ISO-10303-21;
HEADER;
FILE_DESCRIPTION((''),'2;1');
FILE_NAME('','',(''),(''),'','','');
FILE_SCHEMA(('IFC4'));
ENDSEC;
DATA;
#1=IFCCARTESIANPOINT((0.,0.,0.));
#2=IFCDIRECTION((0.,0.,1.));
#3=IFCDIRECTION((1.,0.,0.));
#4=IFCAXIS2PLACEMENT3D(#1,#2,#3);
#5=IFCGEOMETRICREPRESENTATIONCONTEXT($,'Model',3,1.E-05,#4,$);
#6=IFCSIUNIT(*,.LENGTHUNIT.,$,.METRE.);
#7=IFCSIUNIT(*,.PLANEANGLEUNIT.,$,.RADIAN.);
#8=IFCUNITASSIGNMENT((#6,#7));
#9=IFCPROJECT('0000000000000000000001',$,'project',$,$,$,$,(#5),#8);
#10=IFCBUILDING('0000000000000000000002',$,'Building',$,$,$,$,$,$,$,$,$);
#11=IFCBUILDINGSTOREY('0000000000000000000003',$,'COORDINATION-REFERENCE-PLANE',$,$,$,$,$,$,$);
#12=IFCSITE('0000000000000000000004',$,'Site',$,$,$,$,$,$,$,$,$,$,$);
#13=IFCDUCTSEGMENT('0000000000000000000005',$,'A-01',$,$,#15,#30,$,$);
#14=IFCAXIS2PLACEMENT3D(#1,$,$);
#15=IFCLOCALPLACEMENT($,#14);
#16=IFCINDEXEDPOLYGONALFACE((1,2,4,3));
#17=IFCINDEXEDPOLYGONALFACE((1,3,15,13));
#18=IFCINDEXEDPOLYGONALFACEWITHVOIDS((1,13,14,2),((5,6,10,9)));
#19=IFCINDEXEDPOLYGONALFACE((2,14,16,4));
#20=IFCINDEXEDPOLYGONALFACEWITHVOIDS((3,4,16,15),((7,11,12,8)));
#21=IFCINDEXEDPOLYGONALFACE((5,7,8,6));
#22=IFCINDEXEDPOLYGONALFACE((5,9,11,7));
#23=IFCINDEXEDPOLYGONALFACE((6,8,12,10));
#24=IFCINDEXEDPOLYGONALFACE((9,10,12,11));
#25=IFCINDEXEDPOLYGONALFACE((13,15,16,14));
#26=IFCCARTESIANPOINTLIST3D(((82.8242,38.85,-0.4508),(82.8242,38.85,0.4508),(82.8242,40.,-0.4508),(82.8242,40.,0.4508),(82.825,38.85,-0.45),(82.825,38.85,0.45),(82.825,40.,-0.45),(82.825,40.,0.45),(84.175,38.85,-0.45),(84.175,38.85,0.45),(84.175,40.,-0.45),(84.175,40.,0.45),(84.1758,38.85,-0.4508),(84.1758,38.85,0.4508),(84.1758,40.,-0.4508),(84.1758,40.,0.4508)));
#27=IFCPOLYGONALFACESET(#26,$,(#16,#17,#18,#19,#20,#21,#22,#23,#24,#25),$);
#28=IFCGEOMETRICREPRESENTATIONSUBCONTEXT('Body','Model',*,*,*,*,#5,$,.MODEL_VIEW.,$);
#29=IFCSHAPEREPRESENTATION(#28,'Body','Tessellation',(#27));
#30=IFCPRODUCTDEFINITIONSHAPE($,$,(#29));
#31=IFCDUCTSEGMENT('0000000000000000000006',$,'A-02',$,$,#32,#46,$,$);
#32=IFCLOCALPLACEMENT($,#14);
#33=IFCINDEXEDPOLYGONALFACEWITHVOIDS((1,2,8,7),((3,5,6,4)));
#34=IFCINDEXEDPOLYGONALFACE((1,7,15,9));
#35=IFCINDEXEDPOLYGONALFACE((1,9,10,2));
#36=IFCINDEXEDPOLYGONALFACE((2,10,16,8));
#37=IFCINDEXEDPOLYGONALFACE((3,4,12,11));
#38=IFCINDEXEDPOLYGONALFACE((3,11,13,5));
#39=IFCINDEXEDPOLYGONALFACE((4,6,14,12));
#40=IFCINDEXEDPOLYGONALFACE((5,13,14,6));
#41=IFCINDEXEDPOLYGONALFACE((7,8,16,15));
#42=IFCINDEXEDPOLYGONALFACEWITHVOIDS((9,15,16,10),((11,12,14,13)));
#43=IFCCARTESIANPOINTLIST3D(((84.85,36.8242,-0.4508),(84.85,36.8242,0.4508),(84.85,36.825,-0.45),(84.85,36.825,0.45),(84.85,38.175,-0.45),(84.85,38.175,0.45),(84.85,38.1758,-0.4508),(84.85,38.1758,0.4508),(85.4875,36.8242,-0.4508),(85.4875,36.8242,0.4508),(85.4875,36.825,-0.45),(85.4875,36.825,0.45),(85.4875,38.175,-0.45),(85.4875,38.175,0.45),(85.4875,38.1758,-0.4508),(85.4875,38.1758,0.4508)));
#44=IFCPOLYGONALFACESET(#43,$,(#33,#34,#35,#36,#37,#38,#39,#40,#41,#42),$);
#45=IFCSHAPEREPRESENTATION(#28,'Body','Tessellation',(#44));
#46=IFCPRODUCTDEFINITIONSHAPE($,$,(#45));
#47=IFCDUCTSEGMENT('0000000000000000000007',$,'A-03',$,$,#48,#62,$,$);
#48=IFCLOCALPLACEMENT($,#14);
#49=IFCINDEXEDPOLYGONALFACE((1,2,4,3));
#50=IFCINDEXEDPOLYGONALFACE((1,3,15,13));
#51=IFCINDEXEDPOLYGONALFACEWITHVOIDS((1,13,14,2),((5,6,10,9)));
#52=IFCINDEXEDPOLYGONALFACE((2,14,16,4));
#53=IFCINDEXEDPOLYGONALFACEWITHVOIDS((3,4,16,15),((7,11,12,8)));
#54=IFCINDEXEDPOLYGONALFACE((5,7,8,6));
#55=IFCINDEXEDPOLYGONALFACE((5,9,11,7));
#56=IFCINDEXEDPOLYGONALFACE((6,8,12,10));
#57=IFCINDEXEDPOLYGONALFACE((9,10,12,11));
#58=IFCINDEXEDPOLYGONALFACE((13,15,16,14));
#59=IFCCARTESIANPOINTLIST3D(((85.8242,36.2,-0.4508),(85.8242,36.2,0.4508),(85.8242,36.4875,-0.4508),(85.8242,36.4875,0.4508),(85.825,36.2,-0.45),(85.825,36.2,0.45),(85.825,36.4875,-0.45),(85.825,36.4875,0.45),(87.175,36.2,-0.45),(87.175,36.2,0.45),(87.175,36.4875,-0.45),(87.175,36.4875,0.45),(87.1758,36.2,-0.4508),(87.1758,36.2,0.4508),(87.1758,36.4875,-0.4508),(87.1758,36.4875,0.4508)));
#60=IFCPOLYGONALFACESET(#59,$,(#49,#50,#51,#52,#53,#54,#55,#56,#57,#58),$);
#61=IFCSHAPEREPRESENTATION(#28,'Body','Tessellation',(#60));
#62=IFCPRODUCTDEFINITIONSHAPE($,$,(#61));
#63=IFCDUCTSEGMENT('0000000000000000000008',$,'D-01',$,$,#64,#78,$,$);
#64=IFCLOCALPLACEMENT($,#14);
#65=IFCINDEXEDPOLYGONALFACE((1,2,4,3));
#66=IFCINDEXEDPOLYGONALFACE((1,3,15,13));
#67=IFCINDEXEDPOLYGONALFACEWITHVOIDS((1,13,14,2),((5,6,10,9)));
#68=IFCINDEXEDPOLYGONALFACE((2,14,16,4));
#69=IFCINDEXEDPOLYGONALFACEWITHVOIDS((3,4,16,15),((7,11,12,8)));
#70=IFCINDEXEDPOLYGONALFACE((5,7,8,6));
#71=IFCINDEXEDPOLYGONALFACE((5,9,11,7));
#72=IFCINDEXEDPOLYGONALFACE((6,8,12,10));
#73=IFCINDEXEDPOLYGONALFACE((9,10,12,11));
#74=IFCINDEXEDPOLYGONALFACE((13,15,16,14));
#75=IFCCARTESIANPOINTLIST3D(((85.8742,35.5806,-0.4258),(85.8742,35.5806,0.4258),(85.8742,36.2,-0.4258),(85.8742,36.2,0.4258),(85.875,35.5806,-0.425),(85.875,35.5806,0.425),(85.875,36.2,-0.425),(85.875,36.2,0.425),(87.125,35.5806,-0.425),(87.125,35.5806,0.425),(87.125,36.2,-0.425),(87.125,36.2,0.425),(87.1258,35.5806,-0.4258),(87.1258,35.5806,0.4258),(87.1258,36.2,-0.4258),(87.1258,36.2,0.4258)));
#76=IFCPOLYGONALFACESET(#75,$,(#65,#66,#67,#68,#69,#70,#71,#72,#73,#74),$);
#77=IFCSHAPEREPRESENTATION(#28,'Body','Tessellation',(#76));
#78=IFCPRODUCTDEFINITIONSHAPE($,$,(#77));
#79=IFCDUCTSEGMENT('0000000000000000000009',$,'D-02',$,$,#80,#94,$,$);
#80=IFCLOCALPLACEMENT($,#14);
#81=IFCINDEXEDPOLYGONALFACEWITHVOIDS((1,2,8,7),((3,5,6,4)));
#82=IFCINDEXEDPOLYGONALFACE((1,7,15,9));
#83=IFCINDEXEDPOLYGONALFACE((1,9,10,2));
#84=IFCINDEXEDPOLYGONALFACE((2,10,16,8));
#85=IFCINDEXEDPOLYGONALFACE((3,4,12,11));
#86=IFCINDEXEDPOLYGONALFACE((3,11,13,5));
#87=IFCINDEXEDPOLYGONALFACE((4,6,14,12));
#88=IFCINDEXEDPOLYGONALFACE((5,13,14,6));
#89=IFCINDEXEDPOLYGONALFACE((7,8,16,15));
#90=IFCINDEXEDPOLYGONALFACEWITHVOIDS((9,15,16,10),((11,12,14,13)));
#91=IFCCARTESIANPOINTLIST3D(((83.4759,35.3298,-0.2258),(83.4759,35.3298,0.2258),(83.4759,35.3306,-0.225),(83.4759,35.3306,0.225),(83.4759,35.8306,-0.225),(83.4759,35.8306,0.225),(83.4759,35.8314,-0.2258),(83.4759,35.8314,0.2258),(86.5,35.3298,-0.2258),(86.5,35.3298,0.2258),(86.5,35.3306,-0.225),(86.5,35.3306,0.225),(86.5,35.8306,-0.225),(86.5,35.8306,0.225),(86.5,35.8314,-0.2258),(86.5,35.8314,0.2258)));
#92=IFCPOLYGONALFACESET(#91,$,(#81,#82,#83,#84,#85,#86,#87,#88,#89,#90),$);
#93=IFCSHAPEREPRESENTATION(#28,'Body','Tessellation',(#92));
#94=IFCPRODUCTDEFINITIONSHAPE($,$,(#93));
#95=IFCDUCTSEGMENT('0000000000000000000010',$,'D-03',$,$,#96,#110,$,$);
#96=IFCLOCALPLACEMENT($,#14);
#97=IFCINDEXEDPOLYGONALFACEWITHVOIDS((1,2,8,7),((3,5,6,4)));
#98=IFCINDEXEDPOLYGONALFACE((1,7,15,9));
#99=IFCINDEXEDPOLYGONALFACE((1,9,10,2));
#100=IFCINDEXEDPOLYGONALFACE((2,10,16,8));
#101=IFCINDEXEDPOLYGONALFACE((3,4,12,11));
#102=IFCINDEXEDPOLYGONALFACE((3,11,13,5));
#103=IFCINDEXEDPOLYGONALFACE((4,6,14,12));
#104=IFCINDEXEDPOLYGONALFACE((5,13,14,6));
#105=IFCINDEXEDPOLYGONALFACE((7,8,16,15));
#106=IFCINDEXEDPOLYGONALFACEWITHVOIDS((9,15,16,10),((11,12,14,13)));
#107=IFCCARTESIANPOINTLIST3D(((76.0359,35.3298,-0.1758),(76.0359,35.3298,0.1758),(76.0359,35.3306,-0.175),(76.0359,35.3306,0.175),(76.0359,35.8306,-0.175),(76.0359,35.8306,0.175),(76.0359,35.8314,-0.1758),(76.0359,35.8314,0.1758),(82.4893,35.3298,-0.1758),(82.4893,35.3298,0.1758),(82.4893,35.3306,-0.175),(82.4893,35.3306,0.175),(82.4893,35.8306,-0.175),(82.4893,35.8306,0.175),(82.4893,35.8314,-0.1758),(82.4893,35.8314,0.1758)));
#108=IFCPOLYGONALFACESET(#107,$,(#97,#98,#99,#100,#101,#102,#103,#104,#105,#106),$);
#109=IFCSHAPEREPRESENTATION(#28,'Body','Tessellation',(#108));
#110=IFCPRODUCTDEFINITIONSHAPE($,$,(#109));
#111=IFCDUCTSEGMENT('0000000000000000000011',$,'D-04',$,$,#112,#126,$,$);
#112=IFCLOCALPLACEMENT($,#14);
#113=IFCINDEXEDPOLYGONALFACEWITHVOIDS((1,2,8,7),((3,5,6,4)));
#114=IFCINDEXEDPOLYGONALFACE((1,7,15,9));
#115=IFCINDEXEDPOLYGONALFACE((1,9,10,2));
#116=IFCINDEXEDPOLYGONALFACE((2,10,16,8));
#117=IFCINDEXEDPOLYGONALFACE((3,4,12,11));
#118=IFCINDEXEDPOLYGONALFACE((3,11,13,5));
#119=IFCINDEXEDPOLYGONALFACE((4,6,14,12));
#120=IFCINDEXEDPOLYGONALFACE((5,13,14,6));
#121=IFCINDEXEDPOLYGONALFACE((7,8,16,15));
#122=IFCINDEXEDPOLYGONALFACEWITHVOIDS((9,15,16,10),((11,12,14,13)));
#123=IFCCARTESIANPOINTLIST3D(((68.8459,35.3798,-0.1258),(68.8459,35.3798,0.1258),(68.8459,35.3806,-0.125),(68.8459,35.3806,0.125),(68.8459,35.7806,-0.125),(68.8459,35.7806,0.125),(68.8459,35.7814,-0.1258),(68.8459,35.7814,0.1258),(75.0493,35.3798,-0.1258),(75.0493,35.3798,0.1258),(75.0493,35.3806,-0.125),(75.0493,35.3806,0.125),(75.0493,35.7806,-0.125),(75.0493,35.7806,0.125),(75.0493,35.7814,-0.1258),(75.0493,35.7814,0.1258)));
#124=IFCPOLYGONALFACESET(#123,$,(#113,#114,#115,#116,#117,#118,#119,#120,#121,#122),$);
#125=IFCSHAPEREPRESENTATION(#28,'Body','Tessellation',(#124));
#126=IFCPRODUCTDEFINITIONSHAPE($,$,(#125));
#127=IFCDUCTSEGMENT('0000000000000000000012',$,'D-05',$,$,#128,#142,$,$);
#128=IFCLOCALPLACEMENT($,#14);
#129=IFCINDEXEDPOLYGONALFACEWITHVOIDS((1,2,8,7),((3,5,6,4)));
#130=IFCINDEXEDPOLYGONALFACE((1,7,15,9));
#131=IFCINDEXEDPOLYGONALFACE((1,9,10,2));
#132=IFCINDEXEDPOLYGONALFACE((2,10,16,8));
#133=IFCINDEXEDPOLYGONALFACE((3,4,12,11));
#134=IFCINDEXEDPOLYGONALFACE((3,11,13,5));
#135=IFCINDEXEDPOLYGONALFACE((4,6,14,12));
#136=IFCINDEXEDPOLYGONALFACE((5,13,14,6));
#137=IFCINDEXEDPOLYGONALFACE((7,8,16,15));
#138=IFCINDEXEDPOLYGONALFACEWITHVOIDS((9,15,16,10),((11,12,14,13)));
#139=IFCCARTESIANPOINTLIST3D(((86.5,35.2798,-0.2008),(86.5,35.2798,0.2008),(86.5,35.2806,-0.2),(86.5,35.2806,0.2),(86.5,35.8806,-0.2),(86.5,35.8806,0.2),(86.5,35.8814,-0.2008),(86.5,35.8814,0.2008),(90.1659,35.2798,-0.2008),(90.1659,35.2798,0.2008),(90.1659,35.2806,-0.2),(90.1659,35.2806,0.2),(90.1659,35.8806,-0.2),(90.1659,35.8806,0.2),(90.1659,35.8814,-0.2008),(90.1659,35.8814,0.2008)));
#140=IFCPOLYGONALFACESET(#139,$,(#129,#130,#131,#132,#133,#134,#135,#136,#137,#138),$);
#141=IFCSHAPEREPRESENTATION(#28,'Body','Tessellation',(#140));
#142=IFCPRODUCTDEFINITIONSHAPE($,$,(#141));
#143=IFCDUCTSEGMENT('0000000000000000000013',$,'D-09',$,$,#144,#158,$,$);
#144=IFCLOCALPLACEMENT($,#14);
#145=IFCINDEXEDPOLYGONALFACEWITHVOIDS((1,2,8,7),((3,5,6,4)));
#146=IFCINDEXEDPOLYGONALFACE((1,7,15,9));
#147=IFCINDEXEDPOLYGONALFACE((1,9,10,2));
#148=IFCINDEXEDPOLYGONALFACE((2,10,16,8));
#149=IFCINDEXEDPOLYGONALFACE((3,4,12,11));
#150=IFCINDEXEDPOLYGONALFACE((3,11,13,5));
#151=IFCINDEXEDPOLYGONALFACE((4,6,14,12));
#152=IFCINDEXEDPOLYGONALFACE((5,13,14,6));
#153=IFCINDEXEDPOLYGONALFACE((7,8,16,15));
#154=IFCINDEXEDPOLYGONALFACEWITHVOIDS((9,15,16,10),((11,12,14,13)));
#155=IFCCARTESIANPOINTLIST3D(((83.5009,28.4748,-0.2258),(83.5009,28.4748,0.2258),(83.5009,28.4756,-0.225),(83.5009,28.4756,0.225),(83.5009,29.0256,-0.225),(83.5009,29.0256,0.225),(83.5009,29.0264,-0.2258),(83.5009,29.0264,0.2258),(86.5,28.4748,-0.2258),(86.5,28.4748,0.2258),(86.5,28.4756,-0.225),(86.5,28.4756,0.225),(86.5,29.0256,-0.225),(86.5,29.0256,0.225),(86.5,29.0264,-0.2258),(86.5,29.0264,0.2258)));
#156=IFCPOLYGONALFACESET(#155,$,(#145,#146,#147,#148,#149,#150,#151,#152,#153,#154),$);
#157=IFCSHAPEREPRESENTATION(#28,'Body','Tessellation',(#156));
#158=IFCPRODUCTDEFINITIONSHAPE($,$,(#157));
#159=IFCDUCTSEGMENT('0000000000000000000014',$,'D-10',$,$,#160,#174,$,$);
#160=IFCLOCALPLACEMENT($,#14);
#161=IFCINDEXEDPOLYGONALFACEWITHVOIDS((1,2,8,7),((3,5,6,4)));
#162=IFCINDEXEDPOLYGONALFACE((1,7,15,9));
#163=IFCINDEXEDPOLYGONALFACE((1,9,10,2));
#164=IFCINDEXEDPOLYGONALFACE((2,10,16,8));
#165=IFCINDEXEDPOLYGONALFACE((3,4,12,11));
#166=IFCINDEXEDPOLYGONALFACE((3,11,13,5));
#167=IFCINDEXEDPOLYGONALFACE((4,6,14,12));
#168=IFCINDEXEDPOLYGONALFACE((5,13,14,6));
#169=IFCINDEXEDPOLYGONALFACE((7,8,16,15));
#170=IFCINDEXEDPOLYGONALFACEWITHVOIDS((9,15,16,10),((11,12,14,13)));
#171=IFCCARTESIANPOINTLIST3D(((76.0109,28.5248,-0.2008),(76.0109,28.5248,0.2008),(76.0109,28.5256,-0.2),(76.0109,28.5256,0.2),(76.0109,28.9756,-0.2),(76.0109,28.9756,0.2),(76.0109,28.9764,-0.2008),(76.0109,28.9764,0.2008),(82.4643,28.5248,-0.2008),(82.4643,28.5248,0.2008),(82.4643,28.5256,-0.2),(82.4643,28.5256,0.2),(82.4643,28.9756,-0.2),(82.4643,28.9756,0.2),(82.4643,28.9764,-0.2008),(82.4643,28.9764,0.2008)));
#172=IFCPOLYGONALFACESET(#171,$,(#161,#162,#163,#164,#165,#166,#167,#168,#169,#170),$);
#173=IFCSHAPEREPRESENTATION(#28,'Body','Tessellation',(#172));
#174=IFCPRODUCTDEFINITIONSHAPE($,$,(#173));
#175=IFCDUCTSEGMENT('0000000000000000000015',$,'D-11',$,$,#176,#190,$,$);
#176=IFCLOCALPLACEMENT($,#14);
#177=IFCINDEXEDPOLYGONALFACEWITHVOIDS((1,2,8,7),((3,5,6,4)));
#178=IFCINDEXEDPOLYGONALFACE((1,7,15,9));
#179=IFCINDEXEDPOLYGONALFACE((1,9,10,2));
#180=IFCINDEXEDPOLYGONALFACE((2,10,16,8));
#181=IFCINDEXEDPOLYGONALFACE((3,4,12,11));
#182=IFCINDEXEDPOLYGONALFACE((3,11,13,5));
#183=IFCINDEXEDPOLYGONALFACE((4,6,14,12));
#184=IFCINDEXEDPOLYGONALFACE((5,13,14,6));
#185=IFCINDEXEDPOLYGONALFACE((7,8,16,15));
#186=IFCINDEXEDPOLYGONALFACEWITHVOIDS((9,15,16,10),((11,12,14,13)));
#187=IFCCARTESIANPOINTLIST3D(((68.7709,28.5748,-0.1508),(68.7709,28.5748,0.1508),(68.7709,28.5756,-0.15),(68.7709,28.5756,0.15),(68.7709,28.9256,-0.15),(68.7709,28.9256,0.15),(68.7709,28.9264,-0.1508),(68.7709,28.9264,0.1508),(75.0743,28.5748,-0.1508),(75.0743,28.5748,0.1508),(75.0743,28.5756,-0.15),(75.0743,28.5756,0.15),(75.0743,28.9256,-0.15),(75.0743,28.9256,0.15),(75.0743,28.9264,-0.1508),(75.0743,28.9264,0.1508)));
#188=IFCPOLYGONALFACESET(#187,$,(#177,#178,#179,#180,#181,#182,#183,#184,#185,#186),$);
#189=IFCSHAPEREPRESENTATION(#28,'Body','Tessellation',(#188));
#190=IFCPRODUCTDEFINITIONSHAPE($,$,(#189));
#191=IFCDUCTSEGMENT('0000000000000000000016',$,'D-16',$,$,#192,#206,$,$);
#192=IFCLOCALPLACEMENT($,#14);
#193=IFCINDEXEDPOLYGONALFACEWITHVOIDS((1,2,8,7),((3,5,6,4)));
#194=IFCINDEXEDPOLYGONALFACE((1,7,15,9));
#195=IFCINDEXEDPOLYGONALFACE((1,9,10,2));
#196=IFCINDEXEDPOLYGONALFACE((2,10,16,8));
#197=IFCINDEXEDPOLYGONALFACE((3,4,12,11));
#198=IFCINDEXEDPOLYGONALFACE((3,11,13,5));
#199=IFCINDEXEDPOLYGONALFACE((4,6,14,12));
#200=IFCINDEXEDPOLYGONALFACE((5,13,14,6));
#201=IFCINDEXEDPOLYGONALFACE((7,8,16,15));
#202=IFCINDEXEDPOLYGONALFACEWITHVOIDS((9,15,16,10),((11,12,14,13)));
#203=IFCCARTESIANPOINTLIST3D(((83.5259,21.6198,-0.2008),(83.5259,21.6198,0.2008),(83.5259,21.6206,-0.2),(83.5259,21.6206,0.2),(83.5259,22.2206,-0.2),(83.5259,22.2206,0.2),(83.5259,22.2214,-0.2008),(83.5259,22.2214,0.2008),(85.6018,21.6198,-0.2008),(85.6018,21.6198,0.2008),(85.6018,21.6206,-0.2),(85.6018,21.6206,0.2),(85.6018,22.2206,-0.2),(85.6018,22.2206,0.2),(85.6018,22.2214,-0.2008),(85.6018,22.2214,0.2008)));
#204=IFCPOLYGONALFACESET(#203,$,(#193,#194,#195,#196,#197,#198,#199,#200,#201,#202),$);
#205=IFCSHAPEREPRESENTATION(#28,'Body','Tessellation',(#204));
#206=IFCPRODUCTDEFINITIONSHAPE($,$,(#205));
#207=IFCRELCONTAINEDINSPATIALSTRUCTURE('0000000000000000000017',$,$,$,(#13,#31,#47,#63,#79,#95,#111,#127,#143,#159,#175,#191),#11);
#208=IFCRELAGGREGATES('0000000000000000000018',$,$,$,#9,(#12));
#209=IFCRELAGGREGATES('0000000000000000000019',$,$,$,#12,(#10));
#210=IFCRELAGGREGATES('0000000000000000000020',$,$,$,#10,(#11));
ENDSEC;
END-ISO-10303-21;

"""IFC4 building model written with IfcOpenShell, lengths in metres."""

from ifc_helpers import new_model, si_unit, frame, origin, origin_with_axes, place, context, subcontext, project, spatial, hollow_rectangle, extrude, element, save


model = new_model("IFC4")

# Units and contexts
model_context = context("Model", 3, precision=1e-05, world=origin_with_axes())
body_context = subcontext(model_context, "Body", "Model", "MODEL_VIEW")
ifc_project = project(units=[si_unit("LENGTHUNIT", "METRE"), si_unit("PLANEANGLEUNIT", "RADIAN")], contexts=[model_context])

# Site, building, storey
site = spatial("IfcSite", under=ifc_project, Name="Site")
building = spatial("IfcBuilding", under=site, Name="Building")
storey = spatial("IfcBuildingStorey", under=building, Name="COORDINATION-REFERENCE-PLANE")

# Duct segments
duct_segment_1_placement = place(None, frame((83.5, 38.85, 0.0), z_axis=(0.0, 1.0, 0.0), x_axis=(1.0, 0.0, 0.0)))
element("IfcDuctSegment", 1, at=duct_segment_1_placement, inside=storey, Name="A-01", context=body_context, shape_type="SweptSolid", body=[
    extrude(hollow_rectangle(XDim=1.3516, YDim=0.9016, WallThickness=0.0008), origin(), (0.0, 0.0, 1.0), 1.15),
])
duct_segment_2_placement = place(None, frame((84.85, 37.5, 0.0), z_axis=(1.0, 0.0, 0.0), x_axis=(0.0, 1.0, 0.0)))
element("IfcDuctSegment", 2, at=duct_segment_2_placement, inside=storey, Name="A-02", context=body_context, shape_type="SweptSolid", body=[
    extrude(hollow_rectangle(XDim=1.3516, YDim=0.9016, WallThickness=0.0008), origin(), (0.0, 0.0, 1.0), 0.6375),
])
duct_segment_3_placement = place(None, frame((86.5, 36.2, 0.0), z_axis=(0.0, 1.0, 0.0), x_axis=(1.0, 0.0, 0.0)))
element("IfcDuctSegment", 3, at=duct_segment_3_placement, inside=storey, Name="A-03", context=body_context, shape_type="SweptSolid", body=[
    extrude(hollow_rectangle(XDim=1.3516, YDim=0.9016, WallThickness=0.0008), origin(), (0.0, 0.0, 1.0), 0.2875),
])
duct_segment_4_placement = place(None, frame((86.5, 35.5806, 0.0), z_axis=(0.0, 1.0, 0.0), x_axis=(1.0, 0.0, 0.0)))
element("IfcDuctSegment", 4, at=duct_segment_4_placement, inside=storey, Name="D-01", context=body_context, shape_type="SweptSolid", body=[
    extrude(hollow_rectangle(XDim=1.2516, YDim=0.8516, WallThickness=0.0008), origin(), (0.0, 0.0, 1.0), 0.6194),
])
duct_segment_5_placement = place(None, frame((83.4759, 35.5806, 0.0), z_axis=(1.0, 0.0, 0.0), x_axis=(0.0, 1.0, 0.0)))
element("IfcDuctSegment", 5, at=duct_segment_5_placement, inside=storey, Name="D-02", context=body_context, shape_type="SweptSolid", body=[
    extrude(hollow_rectangle(XDim=0.5016, YDim=0.4516, WallThickness=0.0008), origin(), (0.0, 0.0, 1.0), 3.0241),
])
duct_segment_6_placement = place(None, frame((76.0359, 35.5806, 0.0), z_axis=(1.0, 0.0, 0.0), x_axis=(0.0, 1.0, 0.0)))
element("IfcDuctSegment", 6, at=duct_segment_6_placement, inside=storey, Name="D-03", context=body_context, shape_type="SweptSolid", body=[
    extrude(hollow_rectangle(XDim=0.5016, YDim=0.3516, WallThickness=0.0008), origin(), (0.0, 0.0, 1.0), 6.4534),
])
duct_segment_7_placement = place(None, frame((68.8459, 35.5806, 0.0), z_axis=(1.0, 0.0, 0.0), x_axis=(0.0, 1.0, 0.0)))
element("IfcDuctSegment", 7, at=duct_segment_7_placement, inside=storey, Name="D-04", context=body_context, shape_type="SweptSolid", body=[
    extrude(hollow_rectangle(XDim=0.4016, YDim=0.2516, WallThickness=0.0008), origin(), (0.0, 0.0, 1.0), 6.2034),
])
duct_segment_8_placement = place(None, frame((86.5, 35.5806, 0.0), z_axis=(1.0, 0.0, 0.0), x_axis=(0.0, 1.0, 0.0)))
element("IfcDuctSegment", 8, at=duct_segment_8_placement, inside=storey, Name="D-05", context=body_context, shape_type="SweptSolid", body=[
    extrude(hollow_rectangle(XDim=0.6016, YDim=0.4016, WallThickness=0.0008), origin(), (0.0, 0.0, 1.0), 3.6659),
])
duct_segment_9_placement = place(None, frame((83.5009, 28.7506, 0.0), z_axis=(1.0, 0.0, 0.0), x_axis=(0.0, 1.0, 0.0)))
element("IfcDuctSegment", 9, at=duct_segment_9_placement, inside=storey, Name="D-09", context=body_context, shape_type="SweptSolid", body=[
    extrude(hollow_rectangle(XDim=0.5516, YDim=0.4516, WallThickness=0.0008), origin(), (0.0, 0.0, 1.0), 2.9991),
])
duct_segment_10_placement = place(None, frame((76.0109, 28.7506, 0.0), z_axis=(1.0, 0.0, 0.0), x_axis=(0.0, 1.0, 0.0)))
element("IfcDuctSegment", 10, at=duct_segment_10_placement, inside=storey, Name="D-10", context=body_context, shape_type="SweptSolid", body=[
    extrude(hollow_rectangle(XDim=0.4516, YDim=0.4016, WallThickness=0.0008), origin(), (0.0, 0.0, 1.0), 6.4534),
])
duct_segment_11_placement = place(None, frame((68.7709, 28.7506, 0.0), z_axis=(1.0, 0.0, 0.0), x_axis=(0.0, 1.0, 0.0)))
element("IfcDuctSegment", 11, at=duct_segment_11_placement, inside=storey, Name="D-11", context=body_context, shape_type="SweptSolid", body=[
    extrude(hollow_rectangle(XDim=0.3516, YDim=0.3016, WallThickness=0.0008), origin(), (0.0, 0.0, 1.0), 6.3034),
])
duct_segment_12_placement = place(None, frame((83.5259, 21.9206, 0.0), z_axis=(1.0, 0.0, 0.0), x_axis=(0.0, 1.0, 0.0)))
element("IfcDuctSegment", 12, at=duct_segment_12_placement, inside=storey, Name="D-16", context=body_context, shape_type="SweptSolid", body=[
    extrude(hollow_rectangle(XDim=0.6016, YDim=0.4016, WallThickness=0.0008), origin(), (0.0, 0.0, 1.0), 2.0759),
])

save(model, "model.ifc")
